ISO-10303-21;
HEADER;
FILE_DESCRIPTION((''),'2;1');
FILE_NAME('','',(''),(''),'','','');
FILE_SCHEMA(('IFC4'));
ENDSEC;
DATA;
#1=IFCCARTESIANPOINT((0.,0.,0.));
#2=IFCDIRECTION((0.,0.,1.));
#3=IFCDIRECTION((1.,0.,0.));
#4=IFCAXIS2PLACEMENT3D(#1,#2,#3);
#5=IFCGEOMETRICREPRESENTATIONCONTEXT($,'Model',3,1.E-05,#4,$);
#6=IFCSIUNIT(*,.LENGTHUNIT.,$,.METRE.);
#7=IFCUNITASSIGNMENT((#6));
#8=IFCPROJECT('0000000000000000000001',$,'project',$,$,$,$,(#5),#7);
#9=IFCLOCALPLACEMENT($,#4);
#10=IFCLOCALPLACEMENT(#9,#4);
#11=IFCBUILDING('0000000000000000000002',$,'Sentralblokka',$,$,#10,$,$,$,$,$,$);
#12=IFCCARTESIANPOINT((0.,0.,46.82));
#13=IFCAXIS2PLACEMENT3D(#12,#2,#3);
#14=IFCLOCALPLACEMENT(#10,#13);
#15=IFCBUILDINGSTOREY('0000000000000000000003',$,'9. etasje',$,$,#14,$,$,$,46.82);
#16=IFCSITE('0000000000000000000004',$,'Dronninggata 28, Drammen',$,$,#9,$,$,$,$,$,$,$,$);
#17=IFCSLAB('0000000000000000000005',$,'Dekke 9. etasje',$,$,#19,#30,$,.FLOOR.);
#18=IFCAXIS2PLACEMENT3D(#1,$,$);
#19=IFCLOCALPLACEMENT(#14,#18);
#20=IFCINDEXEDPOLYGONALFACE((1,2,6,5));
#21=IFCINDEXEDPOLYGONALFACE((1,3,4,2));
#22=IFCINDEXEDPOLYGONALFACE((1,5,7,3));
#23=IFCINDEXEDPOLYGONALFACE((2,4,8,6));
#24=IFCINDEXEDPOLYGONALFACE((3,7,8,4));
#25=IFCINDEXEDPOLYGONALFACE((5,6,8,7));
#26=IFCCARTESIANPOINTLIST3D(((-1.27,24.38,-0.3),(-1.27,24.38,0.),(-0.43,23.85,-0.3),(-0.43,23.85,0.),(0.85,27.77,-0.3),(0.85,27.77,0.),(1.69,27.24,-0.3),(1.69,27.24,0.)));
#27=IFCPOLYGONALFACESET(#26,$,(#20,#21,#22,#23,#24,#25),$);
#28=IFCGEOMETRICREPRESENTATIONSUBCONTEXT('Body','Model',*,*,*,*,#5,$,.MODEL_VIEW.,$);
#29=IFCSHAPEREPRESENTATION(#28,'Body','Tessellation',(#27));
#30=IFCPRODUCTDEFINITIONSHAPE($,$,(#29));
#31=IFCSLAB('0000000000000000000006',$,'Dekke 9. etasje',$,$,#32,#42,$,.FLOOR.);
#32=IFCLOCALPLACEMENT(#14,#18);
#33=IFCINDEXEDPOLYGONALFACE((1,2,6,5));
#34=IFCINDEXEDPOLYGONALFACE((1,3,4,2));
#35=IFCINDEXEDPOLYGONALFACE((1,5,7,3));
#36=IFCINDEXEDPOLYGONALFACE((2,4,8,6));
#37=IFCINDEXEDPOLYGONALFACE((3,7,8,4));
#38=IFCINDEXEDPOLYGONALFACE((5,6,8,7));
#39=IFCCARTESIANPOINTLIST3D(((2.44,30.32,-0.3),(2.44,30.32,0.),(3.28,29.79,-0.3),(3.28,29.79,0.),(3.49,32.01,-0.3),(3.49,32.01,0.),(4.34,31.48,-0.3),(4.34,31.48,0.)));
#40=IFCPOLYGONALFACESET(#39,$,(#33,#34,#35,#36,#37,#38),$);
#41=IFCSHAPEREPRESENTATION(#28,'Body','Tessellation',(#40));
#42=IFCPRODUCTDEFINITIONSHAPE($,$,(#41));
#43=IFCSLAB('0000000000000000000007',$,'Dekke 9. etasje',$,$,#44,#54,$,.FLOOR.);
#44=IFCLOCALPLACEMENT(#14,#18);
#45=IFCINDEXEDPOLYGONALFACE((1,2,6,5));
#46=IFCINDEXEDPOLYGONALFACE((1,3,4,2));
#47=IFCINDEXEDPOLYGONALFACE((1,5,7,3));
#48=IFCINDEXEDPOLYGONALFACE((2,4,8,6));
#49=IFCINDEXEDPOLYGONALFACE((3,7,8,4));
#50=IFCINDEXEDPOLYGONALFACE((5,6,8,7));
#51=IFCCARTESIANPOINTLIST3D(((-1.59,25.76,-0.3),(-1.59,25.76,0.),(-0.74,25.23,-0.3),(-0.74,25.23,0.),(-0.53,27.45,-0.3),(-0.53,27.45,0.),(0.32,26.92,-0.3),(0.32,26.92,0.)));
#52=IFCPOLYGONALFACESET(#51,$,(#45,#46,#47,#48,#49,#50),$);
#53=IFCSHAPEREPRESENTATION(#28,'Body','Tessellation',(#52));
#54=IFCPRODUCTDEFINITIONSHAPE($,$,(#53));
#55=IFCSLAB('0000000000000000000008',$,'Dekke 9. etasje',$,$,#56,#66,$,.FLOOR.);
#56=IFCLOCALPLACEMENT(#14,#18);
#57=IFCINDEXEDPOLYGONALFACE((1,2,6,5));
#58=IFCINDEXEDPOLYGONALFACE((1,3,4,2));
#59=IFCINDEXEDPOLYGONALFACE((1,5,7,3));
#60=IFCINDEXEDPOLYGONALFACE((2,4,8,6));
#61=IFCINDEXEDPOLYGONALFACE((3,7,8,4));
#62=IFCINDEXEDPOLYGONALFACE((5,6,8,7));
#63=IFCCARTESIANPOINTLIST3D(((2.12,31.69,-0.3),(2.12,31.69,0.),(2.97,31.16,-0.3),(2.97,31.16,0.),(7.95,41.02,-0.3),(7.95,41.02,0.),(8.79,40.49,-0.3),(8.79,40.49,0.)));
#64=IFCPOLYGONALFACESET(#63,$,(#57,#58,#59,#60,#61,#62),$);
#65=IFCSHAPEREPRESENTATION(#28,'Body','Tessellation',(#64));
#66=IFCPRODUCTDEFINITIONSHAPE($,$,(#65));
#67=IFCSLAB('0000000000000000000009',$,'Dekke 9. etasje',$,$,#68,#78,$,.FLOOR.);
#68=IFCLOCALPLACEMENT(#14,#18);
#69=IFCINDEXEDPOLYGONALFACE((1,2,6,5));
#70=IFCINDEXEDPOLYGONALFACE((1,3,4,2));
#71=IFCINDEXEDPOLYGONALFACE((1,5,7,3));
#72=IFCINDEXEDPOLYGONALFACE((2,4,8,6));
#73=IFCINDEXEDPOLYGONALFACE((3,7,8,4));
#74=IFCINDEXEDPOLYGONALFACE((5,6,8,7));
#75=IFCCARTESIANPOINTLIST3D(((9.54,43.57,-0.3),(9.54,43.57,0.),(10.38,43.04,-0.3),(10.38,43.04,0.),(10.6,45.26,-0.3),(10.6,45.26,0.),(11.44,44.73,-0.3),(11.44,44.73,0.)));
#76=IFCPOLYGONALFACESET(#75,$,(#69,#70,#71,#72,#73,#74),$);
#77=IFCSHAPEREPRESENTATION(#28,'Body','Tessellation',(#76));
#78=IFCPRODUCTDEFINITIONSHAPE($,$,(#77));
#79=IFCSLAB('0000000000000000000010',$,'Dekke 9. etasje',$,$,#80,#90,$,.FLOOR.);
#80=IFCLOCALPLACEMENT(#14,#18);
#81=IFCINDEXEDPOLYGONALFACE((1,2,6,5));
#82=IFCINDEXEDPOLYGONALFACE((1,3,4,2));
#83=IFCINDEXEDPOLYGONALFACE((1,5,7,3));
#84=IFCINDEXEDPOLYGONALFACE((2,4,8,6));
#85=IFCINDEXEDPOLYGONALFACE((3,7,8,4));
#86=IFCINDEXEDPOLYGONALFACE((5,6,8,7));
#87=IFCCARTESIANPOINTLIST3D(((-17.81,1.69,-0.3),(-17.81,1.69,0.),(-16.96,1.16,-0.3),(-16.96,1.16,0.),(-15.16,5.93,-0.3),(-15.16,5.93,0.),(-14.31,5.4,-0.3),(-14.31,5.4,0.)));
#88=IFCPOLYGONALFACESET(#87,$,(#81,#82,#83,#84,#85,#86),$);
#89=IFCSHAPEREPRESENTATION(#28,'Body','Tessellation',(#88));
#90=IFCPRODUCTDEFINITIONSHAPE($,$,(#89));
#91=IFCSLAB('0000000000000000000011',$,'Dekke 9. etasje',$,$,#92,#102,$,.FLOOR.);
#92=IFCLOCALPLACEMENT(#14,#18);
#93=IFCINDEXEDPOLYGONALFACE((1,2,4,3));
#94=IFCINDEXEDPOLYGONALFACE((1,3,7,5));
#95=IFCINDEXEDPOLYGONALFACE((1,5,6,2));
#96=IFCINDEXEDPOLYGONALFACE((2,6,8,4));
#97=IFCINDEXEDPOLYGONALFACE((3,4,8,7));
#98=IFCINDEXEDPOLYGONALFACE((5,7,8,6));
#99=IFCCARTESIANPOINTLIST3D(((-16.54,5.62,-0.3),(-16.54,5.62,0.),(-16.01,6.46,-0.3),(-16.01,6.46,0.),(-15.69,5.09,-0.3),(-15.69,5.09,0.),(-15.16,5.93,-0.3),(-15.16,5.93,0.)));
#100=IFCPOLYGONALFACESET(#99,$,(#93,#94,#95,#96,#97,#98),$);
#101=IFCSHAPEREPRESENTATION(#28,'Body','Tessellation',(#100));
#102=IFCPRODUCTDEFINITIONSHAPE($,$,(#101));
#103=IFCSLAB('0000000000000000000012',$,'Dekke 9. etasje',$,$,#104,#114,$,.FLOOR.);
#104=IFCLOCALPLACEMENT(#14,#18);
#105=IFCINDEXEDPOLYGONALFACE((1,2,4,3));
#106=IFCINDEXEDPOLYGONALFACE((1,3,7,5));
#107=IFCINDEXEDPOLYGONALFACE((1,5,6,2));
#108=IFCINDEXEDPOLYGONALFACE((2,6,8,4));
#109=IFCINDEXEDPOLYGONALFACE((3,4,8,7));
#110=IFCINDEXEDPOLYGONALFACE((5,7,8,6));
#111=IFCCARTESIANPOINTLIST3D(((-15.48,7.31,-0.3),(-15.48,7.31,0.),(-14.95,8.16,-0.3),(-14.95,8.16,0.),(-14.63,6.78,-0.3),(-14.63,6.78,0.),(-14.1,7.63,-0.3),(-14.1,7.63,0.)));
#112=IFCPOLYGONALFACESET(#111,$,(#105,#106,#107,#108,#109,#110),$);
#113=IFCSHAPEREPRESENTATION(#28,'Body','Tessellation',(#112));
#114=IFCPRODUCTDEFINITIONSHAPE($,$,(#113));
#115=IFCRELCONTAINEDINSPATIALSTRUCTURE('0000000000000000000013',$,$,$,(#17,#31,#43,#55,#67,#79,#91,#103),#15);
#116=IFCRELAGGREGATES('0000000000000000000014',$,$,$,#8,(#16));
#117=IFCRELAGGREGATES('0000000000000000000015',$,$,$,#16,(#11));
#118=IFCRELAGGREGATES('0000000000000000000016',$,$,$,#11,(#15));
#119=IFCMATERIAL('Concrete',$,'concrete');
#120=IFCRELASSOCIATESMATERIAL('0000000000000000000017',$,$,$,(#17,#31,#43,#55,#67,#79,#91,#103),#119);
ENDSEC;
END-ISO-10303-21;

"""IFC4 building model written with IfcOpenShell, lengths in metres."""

from ifc_helpers import new_model, si_unit, frame, origin_with_axes, place, context, subcontext, project, spatial, polyline, outline, extrude, material, element, save


model = new_model("IFC4")

# Units and contexts
model_context = context("Model", 3, precision=1e-05, world=origin_with_axes())
body_context = subcontext(model_context, "Body", "Model", "MODEL_VIEW")
ifc_project = project(units=[si_unit("LENGTHUNIT", "METRE")], contexts=[model_context])

# Site, building, storey
site_placement = place(None, origin_with_axes())
site = spatial("IfcSite", under=ifc_project, at=site_placement, Name="Dronninggata 28, Drammen")
building_placement = place(site_placement, origin_with_axes())
building = spatial("IfcBuilding", under=site, at=building_placement, Name="Sentralblokka")
storey_placement = place(building_placement, frame((0.0, 0.0, 46.82), z_axis=(0.0, 0.0, 1.0), x_axis=(1.0, 0.0, 0.0)))
storey = spatial("IfcBuildingStorey", under=building, at=storey_placement, Name="9. etasje", Elevation=46.82)

# Slabs
ifc_material = material(Name="Concrete", Category="concrete")
slab_1_placement = place(storey_placement, frame((0.0, 0.0, -46.82), z_axis=(0.0, 0.0, 1.0), x_axis=(1.0, 0.0, 0.0)))
element("IfcSlab", 1, at=slab_1_placement, inside=storey, material=ifc_material, Name="Dekke 9. etasje", PredefinedType="FLOOR", context=body_context, shape_type="SweptSolid", body=[
    extrude(outline(polyline([(-0.43, 23.85), (1.69, 27.24), (0.85, 27.77), (-1.27, 24.38), (-0.43, 23.85)])), frame((0.0, 0.0, 46.52)), (0.0, 0.0, 1.0), 0.3),
])
slab_2_placement = place(storey_placement, frame((0.0, 0.0, -46.82), z_axis=(0.0, 0.0, 1.0), x_axis=(1.0, 0.0, 0.0)))
element("IfcSlab", 2, at=slab_2_placement, inside=storey, material=ifc_material, Name="Dekke 9. etasje", PredefinedType="FLOOR", context=body_context, shape_type="SweptSolid", body=[
    extrude(outline(polyline([(3.28, 29.79), (4.34, 31.48), (3.49, 32.01), (2.44, 30.32), (3.28, 29.79)])), frame((0.0, 0.0, 46.52)), (0.0, 0.0, 1.0), 0.3),
])
slab_3_placement = place(storey_placement, frame((0.0, 0.0, -46.82), z_axis=(0.0, 0.0, 1.0), x_axis=(1.0, 0.0, 0.0)))
element("IfcSlab", 3, at=slab_3_placement, inside=storey, material=ifc_material, Name="Dekke 9. etasje", PredefinedType="FLOOR", context=body_context, shape_type="SweptSolid", body=[
    extrude(outline(polyline([(-0.74, 25.23), (0.32, 26.92), (-0.53, 27.45), (-1.59, 25.76), (-0.74, 25.23)])), frame((0.0, 0.0, 46.52)), (0.0, 0.0, 1.0), 0.3),
])
slab_4_placement = place(storey_placement, frame((0.0, 0.0, -46.82), z_axis=(0.0, 0.0, 1.0), x_axis=(1.0, 0.0, 0.0)))
element("IfcSlab", 4, at=slab_4_placement, inside=storey, material=ifc_material, Name="Dekke 9. etasje", PredefinedType="FLOOR", context=body_context, shape_type="SweptSolid", body=[
    extrude(outline(polyline([(2.97, 31.16), (8.79, 40.49), (7.95, 41.02), (2.12, 31.69), (2.97, 31.16)])), frame((0.0, 0.0, 46.52)), (0.0, 0.0, 1.0), 0.3),
])
slab_5_placement = place(storey_placement, frame((0.0, 0.0, -46.82), z_axis=(0.0, 0.0, 1.0), x_axis=(1.0, 0.0, 0.0)))
element("IfcSlab", 5, at=slab_5_placement, inside=storey, material=ifc_material, Name="Dekke 9. etasje", PredefinedType="FLOOR", context=body_context, shape_type="SweptSolid", body=[
    extrude(outline(polyline([(10.38, 43.04), (11.44, 44.73), (10.6, 45.26), (9.54, 43.57), (10.38, 43.04)])), frame((0.0, 0.0, 46.52)), (0.0, 0.0, 1.0), 0.3),
])
slab_6_placement = place(storey_placement, frame((0.0, 0.0, -46.82), z_axis=(0.0, 0.0, 1.0), x_axis=(1.0, 0.0, 0.0)))
element("IfcSlab", 6, at=slab_6_placement, inside=storey, material=ifc_material, Name="Dekke 9. etasje", PredefinedType="FLOOR", context=body_context, shape_type="SweptSolid", body=[
    extrude(outline(polyline([(-16.96, 1.16), (-14.31, 5.4), (-15.16, 5.93), (-17.81, 1.69), (-16.96, 1.16)])), frame((0.0, 0.0, 46.52)), (0.0, 0.0, 1.0), 0.3),
])
slab_7_placement = place(storey_placement, frame((0.0, 0.0, -46.82), z_axis=(0.0, 0.0, 1.0), x_axis=(1.0, 0.0, 0.0)))
element("IfcSlab", 7, at=slab_7_placement, inside=storey, material=ifc_material, Name="Dekke 9. etasje", PredefinedType="FLOOR", context=body_context, shape_type="SweptSolid", body=[
    extrude(outline(polyline([(-15.69, 5.09), (-15.16, 5.93), (-16.01, 6.46), (-16.54, 5.62), (-15.69, 5.09)])), frame((0.0, 0.0, 46.52)), (0.0, 0.0, 1.0), 0.3),
])
slab_8_placement = place(storey_placement, frame((0.0, 0.0, -46.82), z_axis=(0.0, 0.0, 1.0), x_axis=(1.0, 0.0, 0.0)))
element("IfcSlab", 8, at=slab_8_placement, inside=storey, material=ifc_material, Name="Dekke 9. etasje", PredefinedType="FLOOR", context=body_context, shape_type="SweptSolid", body=[
    extrude(outline(polyline([(-14.63, 6.78), (-14.1, 7.63), (-14.95, 8.16), (-15.48, 7.31), (-14.63, 6.78)])), frame((0.0, 0.0, 46.52)), (0.0, 0.0, 1.0), 0.3),
])

save(model, "model.ifc")
